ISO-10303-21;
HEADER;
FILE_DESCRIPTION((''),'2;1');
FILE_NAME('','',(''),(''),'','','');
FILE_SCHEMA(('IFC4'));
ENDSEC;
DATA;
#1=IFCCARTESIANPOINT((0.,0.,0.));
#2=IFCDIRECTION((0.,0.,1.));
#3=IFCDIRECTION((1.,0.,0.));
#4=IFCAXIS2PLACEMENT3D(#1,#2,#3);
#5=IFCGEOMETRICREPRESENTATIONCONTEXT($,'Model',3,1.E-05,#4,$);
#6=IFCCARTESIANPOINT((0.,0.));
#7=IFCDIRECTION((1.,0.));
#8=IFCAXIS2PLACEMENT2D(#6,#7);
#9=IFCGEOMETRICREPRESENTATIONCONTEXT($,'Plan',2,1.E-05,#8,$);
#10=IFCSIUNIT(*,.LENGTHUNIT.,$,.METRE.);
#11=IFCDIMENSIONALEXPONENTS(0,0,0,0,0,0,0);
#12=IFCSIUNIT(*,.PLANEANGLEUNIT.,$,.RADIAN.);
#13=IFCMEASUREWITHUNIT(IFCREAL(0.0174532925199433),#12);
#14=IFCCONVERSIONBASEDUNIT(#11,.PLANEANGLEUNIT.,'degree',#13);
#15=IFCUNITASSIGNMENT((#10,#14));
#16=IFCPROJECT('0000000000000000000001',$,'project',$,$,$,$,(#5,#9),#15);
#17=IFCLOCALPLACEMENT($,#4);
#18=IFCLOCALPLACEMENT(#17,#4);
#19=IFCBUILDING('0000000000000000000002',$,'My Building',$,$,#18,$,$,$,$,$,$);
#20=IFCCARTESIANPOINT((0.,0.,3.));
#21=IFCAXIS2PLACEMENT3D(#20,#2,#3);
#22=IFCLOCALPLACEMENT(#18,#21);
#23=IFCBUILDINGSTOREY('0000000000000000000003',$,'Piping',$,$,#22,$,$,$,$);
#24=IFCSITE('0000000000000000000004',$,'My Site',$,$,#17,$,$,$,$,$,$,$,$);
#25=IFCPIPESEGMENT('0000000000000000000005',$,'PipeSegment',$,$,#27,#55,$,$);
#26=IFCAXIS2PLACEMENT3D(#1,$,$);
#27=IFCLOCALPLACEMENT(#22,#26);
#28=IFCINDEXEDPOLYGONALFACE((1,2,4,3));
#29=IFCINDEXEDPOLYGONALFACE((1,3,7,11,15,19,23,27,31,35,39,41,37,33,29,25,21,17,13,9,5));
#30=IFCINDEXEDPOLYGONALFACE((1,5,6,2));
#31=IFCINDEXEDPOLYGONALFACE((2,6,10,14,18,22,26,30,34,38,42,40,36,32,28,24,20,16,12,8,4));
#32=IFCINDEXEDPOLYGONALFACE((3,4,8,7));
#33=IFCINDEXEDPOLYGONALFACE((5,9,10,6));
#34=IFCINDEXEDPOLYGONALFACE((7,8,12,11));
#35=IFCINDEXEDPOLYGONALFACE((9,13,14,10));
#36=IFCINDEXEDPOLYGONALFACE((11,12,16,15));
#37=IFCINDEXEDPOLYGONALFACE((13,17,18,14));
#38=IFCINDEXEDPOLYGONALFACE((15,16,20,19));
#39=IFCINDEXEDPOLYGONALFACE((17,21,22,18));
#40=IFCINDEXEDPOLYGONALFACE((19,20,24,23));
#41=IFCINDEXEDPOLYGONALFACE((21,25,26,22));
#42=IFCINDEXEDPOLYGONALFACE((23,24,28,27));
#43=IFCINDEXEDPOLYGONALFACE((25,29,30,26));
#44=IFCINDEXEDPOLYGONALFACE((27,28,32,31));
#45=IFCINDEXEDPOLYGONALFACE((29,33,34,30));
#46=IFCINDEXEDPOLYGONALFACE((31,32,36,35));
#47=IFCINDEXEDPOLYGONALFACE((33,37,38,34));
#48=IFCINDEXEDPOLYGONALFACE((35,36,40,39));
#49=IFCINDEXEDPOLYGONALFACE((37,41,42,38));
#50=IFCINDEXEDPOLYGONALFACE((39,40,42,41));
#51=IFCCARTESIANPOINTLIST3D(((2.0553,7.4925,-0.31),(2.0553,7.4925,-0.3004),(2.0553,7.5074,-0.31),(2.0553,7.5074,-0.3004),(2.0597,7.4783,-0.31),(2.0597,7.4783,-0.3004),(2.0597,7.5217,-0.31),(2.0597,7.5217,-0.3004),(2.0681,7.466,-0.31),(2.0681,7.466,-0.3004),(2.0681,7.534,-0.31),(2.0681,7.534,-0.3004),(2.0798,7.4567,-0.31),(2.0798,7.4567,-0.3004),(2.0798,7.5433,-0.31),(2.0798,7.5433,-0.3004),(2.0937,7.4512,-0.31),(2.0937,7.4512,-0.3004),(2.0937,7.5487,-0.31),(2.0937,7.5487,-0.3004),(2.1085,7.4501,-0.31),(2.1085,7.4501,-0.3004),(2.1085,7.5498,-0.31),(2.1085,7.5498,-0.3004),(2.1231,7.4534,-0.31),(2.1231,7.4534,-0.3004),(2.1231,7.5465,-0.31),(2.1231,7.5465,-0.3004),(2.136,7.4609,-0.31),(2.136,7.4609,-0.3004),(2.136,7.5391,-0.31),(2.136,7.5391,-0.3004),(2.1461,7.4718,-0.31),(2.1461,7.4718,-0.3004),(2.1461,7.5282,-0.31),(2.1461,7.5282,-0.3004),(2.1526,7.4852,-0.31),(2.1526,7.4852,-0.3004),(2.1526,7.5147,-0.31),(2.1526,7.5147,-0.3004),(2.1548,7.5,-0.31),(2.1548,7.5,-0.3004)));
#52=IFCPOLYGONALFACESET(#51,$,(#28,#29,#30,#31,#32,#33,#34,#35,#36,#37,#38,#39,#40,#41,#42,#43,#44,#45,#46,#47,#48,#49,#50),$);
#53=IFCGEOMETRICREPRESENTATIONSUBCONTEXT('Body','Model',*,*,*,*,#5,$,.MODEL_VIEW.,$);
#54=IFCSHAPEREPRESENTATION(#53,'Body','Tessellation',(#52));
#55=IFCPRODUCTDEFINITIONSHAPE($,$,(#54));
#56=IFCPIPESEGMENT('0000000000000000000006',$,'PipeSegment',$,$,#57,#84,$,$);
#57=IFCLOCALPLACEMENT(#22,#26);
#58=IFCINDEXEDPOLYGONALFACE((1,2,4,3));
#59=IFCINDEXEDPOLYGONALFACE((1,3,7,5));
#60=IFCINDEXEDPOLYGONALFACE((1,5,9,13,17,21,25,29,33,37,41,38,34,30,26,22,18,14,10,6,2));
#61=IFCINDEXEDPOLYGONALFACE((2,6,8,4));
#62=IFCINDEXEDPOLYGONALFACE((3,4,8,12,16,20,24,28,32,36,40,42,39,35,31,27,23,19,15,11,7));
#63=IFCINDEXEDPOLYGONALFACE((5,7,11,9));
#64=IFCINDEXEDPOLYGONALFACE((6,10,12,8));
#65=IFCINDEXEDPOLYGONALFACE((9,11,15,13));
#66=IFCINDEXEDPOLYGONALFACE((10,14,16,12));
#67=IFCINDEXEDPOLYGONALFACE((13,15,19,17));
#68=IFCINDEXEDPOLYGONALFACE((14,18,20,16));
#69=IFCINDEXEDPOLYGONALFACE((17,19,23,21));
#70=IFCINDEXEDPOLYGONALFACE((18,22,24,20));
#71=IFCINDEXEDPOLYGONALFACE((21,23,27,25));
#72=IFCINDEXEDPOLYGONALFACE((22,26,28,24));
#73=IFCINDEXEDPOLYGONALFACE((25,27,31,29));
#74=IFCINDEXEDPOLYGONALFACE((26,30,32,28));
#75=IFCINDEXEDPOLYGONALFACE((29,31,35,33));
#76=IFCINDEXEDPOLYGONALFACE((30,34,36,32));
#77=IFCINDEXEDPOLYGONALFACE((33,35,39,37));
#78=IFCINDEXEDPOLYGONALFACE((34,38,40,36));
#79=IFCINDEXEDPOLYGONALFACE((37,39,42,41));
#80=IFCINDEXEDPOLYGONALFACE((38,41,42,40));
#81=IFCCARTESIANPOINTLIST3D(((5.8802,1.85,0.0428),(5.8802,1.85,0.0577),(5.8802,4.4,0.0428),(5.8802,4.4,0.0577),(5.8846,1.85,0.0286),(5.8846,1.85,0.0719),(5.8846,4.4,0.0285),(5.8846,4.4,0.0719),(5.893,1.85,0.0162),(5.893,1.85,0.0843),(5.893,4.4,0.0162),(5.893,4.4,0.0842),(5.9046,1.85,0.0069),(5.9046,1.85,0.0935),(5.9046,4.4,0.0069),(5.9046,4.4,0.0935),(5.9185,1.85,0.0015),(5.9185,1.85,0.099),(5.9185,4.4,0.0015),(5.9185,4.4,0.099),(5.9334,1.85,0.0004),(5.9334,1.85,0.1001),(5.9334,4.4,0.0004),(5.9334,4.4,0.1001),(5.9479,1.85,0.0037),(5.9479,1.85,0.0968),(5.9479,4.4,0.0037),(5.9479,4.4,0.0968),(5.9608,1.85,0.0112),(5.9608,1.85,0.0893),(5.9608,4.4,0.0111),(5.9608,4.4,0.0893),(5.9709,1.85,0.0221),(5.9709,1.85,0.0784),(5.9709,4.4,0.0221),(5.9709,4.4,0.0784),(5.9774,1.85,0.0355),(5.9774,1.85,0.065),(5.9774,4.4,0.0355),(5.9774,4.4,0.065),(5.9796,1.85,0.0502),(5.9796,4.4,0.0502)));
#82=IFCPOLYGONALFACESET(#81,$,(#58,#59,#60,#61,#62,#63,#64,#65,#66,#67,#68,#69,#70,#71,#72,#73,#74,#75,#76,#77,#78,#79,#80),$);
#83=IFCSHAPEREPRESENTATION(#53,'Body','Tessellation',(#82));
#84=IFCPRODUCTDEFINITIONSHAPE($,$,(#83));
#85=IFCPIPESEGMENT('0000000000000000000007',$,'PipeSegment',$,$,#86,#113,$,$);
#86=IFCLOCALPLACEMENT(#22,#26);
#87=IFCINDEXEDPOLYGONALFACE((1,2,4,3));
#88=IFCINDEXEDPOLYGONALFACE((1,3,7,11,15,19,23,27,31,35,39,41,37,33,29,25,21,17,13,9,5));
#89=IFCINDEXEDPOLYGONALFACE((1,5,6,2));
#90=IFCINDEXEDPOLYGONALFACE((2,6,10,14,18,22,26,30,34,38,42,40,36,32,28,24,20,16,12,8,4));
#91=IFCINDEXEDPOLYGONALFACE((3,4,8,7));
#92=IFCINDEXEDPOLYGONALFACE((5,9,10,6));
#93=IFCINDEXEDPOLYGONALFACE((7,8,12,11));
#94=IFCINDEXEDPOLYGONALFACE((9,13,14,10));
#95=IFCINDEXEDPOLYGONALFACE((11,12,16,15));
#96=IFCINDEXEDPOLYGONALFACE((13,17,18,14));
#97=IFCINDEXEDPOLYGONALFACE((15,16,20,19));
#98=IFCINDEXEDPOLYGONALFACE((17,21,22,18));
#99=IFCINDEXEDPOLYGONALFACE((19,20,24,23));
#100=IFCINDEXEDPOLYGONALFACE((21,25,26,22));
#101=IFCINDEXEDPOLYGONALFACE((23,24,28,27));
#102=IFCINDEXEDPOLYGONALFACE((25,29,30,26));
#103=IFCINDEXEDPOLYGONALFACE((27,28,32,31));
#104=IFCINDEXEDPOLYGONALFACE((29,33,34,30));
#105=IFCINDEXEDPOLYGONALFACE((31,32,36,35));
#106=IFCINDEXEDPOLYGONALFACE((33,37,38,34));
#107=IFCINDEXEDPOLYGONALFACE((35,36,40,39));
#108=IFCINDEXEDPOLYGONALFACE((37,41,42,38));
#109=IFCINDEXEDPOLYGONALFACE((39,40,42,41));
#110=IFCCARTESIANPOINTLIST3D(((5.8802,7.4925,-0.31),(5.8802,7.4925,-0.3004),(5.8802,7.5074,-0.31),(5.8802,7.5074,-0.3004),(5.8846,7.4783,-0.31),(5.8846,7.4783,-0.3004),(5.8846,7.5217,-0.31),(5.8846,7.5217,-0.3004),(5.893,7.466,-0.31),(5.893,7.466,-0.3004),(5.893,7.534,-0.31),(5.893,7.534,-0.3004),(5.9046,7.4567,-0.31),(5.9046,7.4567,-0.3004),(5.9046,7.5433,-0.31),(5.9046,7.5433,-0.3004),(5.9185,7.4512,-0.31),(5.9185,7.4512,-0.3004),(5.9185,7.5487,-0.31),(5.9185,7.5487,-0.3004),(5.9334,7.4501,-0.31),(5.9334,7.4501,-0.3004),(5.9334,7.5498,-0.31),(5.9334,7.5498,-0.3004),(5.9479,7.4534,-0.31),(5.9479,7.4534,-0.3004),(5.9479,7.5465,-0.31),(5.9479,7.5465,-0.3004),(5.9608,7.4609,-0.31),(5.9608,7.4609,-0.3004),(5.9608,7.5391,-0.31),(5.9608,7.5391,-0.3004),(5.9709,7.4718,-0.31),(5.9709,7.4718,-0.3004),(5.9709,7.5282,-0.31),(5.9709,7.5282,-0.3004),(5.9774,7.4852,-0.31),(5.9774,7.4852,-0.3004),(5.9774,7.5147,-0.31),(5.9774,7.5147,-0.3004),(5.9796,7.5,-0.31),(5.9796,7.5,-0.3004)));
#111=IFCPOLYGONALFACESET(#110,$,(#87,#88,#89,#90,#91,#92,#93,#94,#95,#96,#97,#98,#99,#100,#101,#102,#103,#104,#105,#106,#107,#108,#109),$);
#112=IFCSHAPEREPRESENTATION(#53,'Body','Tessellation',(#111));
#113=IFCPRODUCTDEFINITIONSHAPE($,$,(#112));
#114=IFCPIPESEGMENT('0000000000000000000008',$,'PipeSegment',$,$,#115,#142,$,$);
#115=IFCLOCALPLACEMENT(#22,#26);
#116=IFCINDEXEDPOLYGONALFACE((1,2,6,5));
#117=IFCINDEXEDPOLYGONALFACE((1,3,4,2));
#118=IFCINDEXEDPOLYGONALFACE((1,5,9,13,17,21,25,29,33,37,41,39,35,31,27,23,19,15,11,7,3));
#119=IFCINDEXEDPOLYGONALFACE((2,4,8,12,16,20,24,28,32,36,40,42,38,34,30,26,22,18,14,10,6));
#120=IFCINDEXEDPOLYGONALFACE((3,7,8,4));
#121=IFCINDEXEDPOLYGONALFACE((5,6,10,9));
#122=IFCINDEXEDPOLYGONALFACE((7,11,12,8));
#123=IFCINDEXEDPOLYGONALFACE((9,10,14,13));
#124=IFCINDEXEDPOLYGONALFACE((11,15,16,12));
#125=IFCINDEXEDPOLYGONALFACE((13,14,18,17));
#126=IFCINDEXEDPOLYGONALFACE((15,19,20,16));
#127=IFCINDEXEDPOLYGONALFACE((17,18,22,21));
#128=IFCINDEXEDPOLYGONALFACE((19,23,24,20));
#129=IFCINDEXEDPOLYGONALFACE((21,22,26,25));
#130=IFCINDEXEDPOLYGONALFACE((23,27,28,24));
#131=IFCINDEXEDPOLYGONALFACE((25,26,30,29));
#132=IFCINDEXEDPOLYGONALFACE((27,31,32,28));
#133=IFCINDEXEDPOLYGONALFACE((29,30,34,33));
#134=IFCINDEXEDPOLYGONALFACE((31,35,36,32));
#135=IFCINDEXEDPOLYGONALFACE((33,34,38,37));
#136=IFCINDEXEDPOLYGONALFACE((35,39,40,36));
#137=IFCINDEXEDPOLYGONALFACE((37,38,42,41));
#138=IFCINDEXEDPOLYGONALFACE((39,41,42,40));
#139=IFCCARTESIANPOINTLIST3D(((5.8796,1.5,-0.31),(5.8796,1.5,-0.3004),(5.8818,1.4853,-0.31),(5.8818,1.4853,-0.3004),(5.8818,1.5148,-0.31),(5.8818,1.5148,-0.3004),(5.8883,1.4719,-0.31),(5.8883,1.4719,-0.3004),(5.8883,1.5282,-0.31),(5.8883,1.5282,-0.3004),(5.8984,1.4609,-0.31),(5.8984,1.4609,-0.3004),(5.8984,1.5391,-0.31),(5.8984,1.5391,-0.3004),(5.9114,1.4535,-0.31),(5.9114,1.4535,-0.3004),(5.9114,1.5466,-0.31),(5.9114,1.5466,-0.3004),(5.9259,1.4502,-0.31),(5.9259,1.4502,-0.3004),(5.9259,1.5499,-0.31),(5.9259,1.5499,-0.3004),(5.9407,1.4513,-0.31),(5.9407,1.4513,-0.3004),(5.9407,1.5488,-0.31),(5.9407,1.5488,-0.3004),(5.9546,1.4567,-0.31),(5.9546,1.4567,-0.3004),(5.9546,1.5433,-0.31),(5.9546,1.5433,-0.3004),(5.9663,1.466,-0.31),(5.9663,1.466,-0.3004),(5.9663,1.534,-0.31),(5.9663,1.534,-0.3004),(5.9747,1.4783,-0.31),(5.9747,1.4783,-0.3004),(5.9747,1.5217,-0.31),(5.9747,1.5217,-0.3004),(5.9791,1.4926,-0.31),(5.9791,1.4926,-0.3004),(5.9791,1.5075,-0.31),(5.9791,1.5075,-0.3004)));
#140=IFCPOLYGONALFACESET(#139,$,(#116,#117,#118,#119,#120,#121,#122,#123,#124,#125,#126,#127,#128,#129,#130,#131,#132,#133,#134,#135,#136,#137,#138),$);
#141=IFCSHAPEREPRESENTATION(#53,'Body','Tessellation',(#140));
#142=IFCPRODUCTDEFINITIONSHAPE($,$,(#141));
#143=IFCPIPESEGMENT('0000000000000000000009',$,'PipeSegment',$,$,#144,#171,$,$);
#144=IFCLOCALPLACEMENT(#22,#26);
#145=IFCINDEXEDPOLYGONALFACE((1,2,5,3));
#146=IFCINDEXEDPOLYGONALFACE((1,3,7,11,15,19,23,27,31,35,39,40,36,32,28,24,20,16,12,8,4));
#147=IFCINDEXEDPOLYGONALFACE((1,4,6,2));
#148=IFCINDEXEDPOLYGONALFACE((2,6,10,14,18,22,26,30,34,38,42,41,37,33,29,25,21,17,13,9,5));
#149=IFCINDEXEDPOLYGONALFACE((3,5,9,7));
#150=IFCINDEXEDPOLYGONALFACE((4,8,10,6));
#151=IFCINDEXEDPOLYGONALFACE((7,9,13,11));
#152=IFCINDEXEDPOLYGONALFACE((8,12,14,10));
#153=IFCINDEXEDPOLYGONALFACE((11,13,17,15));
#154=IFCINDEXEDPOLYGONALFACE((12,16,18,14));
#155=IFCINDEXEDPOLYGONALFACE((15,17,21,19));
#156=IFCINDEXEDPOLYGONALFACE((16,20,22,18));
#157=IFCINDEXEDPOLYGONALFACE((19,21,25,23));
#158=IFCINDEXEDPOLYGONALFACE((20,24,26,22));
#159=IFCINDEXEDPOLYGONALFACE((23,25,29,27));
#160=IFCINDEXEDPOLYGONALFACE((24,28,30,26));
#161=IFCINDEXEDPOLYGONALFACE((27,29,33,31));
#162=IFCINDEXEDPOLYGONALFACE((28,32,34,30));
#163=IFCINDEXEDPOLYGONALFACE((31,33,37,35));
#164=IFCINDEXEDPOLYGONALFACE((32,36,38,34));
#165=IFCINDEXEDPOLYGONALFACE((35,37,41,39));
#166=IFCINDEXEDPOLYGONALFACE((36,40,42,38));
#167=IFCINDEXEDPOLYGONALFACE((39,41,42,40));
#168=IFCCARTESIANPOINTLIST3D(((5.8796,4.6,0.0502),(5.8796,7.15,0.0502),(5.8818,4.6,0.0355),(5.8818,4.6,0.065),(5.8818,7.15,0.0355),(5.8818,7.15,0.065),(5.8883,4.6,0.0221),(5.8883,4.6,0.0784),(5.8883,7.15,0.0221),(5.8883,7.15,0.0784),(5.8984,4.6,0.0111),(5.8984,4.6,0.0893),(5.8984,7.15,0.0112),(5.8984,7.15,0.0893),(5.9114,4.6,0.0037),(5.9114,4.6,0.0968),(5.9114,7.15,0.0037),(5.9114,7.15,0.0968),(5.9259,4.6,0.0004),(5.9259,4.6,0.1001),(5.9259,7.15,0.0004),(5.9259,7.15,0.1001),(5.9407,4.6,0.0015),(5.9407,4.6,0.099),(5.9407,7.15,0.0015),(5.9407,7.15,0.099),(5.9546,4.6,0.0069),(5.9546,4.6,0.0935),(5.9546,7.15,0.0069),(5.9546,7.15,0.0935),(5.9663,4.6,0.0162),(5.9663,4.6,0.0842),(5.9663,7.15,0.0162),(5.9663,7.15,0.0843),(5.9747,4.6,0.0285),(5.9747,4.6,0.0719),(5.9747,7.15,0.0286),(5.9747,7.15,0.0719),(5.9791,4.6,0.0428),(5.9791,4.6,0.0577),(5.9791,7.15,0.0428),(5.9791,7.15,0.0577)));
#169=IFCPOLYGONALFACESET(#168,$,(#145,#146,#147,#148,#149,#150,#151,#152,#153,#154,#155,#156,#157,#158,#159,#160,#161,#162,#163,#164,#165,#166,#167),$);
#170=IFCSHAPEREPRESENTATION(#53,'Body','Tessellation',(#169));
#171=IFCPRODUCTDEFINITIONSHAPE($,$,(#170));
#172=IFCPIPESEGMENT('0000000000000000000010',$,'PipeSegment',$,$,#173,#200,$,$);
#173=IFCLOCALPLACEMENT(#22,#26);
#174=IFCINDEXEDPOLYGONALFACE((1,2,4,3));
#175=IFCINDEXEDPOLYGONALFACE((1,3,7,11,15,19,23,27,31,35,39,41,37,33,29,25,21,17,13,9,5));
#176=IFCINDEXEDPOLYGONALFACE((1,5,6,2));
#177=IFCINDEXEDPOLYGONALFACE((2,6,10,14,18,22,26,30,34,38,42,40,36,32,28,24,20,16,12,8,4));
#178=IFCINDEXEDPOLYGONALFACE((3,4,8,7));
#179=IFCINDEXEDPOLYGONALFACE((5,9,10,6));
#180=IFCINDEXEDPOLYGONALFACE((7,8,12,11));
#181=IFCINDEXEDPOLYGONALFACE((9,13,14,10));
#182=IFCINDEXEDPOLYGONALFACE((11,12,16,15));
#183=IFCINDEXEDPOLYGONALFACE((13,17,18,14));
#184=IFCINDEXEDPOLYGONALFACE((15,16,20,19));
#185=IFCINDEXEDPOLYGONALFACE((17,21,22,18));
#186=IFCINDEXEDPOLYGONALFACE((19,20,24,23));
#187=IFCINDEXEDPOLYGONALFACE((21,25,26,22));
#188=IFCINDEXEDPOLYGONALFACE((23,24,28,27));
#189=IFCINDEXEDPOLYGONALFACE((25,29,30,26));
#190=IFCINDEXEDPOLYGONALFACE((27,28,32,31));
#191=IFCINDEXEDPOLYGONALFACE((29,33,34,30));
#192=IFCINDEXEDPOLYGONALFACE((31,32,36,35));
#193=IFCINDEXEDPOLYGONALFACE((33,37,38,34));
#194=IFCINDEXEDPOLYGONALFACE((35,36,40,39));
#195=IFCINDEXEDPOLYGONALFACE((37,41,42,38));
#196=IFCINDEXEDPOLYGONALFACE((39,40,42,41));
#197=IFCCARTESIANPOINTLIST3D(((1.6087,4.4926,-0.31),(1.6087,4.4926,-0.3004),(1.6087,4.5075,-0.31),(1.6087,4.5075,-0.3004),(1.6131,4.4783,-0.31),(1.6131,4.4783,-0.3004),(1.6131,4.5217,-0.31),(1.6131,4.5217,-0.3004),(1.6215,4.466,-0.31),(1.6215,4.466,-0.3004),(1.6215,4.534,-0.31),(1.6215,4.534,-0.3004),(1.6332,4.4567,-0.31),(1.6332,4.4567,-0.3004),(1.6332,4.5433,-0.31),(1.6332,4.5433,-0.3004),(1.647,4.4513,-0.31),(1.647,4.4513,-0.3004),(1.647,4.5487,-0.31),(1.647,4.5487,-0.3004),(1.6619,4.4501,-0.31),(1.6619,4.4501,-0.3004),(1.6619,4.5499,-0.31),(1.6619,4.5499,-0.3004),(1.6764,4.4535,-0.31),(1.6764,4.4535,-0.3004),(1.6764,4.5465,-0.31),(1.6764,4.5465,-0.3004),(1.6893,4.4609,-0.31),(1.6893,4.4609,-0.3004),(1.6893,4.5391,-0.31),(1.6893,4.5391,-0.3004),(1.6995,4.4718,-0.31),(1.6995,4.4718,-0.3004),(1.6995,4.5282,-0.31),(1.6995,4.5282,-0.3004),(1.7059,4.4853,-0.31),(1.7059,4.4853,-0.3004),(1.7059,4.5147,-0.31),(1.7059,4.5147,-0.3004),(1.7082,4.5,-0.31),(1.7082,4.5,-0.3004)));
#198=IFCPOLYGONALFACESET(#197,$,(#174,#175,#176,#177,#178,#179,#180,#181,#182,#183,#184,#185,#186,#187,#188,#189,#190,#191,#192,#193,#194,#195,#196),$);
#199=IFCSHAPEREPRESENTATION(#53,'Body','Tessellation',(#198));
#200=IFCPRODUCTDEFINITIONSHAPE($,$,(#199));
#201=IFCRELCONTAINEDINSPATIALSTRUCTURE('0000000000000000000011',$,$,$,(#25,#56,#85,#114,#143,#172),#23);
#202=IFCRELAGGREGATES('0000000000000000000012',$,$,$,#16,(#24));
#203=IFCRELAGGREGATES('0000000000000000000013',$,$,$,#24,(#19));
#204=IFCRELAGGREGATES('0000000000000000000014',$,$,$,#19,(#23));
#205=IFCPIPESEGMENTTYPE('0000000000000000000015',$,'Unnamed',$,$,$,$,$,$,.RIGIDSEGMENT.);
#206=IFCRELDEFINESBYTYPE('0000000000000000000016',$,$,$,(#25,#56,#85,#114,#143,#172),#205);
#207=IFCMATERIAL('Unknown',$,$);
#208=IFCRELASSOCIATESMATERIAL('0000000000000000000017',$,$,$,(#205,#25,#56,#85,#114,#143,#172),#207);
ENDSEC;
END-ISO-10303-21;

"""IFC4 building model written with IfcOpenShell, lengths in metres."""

from ifc_helpers import new_model, entity, si_unit, converted_unit, frame, origin_with_axes, origin_2d_with_axis, place, context, subcontext, project, spatial, circle, extrude, material, material_profile, profile_set, profile_usage, type_object, element, save


model = new_model("IFC4")

# Units and contexts
model_context = context("Model", 3, precision=1e-05, world=origin_with_axes())
plan_context = context("Plan", 2, precision=1e-05, world=origin_2d_with_axis())
body_context = subcontext(model_context, "Body", "Model", "MODEL_VIEW")
ifc_project = project(units=[si_unit("LENGTHUNIT", "METRE"), converted_unit("PLANEANGLEUNIT", "degree", entity("IfcReal", 0.0174532925199433), si_unit("PLANEANGLEUNIT", "RADIAN"), dimensions=[0, 0, 0, 0, 0, 0, 0])], contexts=[model_context, plan_context])

# Site, building, storey
site_placement = place(None, origin_with_axes())
site = spatial("IfcSite", under=ifc_project, at=site_placement, Name="My Site")
building_placement = place(site_placement, origin_with_axes())
building = spatial("IfcBuilding", under=site, at=building_placement, Name="My Building")
storey_placement = place(building_placement, frame((0.0, 0.0, 3.0), z_axis=(0.0, 0.0, 1.0), x_axis=(1.0, 0.0, 0.0)))
storey = spatial("IfcBuildingStorey", under=building, at=storey_placement, Name="Piping")

# Pipe segments
ifc_material = material(Name="Unknown")
ifc_material_profile_1 = material_profile(ifc_material, circle(Radius=0.05))
ifc_profile_set_1 = profile_set([ifc_material_profile_1])
pipe_segment_type = type_object("IfcPipeSegmentType", Name="Unnamed", PredefinedType="RIGIDSEGMENT", material=ifc_profile_set_1)
ifc_profile_usage_1 = profile_usage(ifc_profile_set_1, cardinal=16)
pipe_segment_1_placement = place(storey_placement, frame((2.1048, 7.5, -0.3004), z_axis=(0.0, 0.0, -1.0), x_axis=(1.0, 0.0, 0.0)))
element("IfcPipeSegment", 1, at=pipe_segment_1_placement, inside=storey, type_object=pipe_segment_type, material=ifc_profile_usage_1, Name="PipeSegment", context=body_context, shape_type="SweptSolid", body=[
    extrude(circle(Radius=0.05), origin_with_axes(), (0.0, 0.0, 1.0), 0.0096),
])
ifc_profile_usage_2 = profile_usage(ifc_profile_set_1, cardinal=2)
pipe_segment_2_placement = place(storey_placement, frame((5.9296, 4.4, 0.0002), z_axis=(0.0, -1.0, 0.000006), x_axis=(1.0, 0.0, 0.0)))
element("IfcPipeSegment", 2, at=pipe_segment_2_placement, inside=storey, type_object=pipe_segment_type, material=ifc_profile_usage_2, Name="PipeSegment", context=body_context, shape_type="SweptSolid", body=[
    extrude(circle(Radius=0.05), frame((0.0, 0.05, 0.0), z_axis=(0.0, 0.0, 1.0), x_axis=(1.0, 0.0, 0.0)), (0.0, 0.0, 1.0), 2.55),
])
ifc_profile_usage_3 = profile_usage(ifc_profile_set_1, cardinal=16)
pipe_segment_3_placement = place(storey_placement, frame((5.9296, 7.5, -0.3004), z_axis=(0.0, 0.0, -1.0), x_axis=(1.0, 0.0, 0.0)))
element("IfcPipeSegment", 3, at=pipe_segment_3_placement, inside=storey, type_object=pipe_segment_type, material=ifc_profile_usage_3, Name="PipeSegment", context=body_context, shape_type="SweptSolid", body=[
    extrude(circle(Radius=0.05), origin_with_axes(), (0.0, 0.0, 1.0), 0.0096),
])
ifc_profile_usage_4 = profile_usage(ifc_profile_set_1, cardinal=16)
pipe_segment_4_placement = place(storey_placement, frame((5.9296, 1.5, -0.3004), z_axis=(0.0, 0.0, -1.0), x_axis=(-1.0, 0.0, 0.0)))
element("IfcPipeSegment", 4, at=pipe_segment_4_placement, inside=storey, type_object=pipe_segment_type, material=ifc_profile_usage_4, Name="PipeSegment", context=body_context, shape_type="SweptSolid", body=[
    extrude(circle(Radius=0.05), origin_with_axes(), (0.0, 0.0, 1.0), 0.0096),
])
ifc_profile_usage_5 = profile_usage(ifc_profile_set_1, cardinal=2)
pipe_segment_5_placement = place(storey_placement, frame((5.9296, 4.6, 0.0002), z_axis=(0.0, 1.0, 0.000006), x_axis=(-1.0, 0.0, 0.0)))
element("IfcPipeSegment", 5, at=pipe_segment_5_placement, inside=storey, type_object=pipe_segment_type, material=ifc_profile_usage_5, Name="PipeSegment", context=body_context, shape_type="SweptSolid", body=[
    extrude(circle(Radius=0.05), frame((0.0, 0.05, 0.0), z_axis=(0.0, 0.0, 1.0), x_axis=(1.0, 0.0, 0.0)), (0.0, 0.0, 1.0), 2.55),
])
ifc_profile_usage_6 = profile_usage(ifc_profile_set_1, cardinal=16)
pipe_segment_6_placement = place(storey_placement, frame((1.6582, 4.5, -0.3004), z_axis=(0.0, 0.0, -1.0), x_axis=(1.0, 0.0, 0.0)))
element("IfcPipeSegment", 6, at=pipe_segment_6_placement, inside=storey, type_object=pipe_segment_type, material=ifc_profile_usage_6, Name="PipeSegment", context=body_context, shape_type="SweptSolid", body=[
    extrude(circle(Radius=0.05), origin_with_axes(), (0.0, 0.0, 1.0), 0.0096),
])

save(model, "model.ifc")
